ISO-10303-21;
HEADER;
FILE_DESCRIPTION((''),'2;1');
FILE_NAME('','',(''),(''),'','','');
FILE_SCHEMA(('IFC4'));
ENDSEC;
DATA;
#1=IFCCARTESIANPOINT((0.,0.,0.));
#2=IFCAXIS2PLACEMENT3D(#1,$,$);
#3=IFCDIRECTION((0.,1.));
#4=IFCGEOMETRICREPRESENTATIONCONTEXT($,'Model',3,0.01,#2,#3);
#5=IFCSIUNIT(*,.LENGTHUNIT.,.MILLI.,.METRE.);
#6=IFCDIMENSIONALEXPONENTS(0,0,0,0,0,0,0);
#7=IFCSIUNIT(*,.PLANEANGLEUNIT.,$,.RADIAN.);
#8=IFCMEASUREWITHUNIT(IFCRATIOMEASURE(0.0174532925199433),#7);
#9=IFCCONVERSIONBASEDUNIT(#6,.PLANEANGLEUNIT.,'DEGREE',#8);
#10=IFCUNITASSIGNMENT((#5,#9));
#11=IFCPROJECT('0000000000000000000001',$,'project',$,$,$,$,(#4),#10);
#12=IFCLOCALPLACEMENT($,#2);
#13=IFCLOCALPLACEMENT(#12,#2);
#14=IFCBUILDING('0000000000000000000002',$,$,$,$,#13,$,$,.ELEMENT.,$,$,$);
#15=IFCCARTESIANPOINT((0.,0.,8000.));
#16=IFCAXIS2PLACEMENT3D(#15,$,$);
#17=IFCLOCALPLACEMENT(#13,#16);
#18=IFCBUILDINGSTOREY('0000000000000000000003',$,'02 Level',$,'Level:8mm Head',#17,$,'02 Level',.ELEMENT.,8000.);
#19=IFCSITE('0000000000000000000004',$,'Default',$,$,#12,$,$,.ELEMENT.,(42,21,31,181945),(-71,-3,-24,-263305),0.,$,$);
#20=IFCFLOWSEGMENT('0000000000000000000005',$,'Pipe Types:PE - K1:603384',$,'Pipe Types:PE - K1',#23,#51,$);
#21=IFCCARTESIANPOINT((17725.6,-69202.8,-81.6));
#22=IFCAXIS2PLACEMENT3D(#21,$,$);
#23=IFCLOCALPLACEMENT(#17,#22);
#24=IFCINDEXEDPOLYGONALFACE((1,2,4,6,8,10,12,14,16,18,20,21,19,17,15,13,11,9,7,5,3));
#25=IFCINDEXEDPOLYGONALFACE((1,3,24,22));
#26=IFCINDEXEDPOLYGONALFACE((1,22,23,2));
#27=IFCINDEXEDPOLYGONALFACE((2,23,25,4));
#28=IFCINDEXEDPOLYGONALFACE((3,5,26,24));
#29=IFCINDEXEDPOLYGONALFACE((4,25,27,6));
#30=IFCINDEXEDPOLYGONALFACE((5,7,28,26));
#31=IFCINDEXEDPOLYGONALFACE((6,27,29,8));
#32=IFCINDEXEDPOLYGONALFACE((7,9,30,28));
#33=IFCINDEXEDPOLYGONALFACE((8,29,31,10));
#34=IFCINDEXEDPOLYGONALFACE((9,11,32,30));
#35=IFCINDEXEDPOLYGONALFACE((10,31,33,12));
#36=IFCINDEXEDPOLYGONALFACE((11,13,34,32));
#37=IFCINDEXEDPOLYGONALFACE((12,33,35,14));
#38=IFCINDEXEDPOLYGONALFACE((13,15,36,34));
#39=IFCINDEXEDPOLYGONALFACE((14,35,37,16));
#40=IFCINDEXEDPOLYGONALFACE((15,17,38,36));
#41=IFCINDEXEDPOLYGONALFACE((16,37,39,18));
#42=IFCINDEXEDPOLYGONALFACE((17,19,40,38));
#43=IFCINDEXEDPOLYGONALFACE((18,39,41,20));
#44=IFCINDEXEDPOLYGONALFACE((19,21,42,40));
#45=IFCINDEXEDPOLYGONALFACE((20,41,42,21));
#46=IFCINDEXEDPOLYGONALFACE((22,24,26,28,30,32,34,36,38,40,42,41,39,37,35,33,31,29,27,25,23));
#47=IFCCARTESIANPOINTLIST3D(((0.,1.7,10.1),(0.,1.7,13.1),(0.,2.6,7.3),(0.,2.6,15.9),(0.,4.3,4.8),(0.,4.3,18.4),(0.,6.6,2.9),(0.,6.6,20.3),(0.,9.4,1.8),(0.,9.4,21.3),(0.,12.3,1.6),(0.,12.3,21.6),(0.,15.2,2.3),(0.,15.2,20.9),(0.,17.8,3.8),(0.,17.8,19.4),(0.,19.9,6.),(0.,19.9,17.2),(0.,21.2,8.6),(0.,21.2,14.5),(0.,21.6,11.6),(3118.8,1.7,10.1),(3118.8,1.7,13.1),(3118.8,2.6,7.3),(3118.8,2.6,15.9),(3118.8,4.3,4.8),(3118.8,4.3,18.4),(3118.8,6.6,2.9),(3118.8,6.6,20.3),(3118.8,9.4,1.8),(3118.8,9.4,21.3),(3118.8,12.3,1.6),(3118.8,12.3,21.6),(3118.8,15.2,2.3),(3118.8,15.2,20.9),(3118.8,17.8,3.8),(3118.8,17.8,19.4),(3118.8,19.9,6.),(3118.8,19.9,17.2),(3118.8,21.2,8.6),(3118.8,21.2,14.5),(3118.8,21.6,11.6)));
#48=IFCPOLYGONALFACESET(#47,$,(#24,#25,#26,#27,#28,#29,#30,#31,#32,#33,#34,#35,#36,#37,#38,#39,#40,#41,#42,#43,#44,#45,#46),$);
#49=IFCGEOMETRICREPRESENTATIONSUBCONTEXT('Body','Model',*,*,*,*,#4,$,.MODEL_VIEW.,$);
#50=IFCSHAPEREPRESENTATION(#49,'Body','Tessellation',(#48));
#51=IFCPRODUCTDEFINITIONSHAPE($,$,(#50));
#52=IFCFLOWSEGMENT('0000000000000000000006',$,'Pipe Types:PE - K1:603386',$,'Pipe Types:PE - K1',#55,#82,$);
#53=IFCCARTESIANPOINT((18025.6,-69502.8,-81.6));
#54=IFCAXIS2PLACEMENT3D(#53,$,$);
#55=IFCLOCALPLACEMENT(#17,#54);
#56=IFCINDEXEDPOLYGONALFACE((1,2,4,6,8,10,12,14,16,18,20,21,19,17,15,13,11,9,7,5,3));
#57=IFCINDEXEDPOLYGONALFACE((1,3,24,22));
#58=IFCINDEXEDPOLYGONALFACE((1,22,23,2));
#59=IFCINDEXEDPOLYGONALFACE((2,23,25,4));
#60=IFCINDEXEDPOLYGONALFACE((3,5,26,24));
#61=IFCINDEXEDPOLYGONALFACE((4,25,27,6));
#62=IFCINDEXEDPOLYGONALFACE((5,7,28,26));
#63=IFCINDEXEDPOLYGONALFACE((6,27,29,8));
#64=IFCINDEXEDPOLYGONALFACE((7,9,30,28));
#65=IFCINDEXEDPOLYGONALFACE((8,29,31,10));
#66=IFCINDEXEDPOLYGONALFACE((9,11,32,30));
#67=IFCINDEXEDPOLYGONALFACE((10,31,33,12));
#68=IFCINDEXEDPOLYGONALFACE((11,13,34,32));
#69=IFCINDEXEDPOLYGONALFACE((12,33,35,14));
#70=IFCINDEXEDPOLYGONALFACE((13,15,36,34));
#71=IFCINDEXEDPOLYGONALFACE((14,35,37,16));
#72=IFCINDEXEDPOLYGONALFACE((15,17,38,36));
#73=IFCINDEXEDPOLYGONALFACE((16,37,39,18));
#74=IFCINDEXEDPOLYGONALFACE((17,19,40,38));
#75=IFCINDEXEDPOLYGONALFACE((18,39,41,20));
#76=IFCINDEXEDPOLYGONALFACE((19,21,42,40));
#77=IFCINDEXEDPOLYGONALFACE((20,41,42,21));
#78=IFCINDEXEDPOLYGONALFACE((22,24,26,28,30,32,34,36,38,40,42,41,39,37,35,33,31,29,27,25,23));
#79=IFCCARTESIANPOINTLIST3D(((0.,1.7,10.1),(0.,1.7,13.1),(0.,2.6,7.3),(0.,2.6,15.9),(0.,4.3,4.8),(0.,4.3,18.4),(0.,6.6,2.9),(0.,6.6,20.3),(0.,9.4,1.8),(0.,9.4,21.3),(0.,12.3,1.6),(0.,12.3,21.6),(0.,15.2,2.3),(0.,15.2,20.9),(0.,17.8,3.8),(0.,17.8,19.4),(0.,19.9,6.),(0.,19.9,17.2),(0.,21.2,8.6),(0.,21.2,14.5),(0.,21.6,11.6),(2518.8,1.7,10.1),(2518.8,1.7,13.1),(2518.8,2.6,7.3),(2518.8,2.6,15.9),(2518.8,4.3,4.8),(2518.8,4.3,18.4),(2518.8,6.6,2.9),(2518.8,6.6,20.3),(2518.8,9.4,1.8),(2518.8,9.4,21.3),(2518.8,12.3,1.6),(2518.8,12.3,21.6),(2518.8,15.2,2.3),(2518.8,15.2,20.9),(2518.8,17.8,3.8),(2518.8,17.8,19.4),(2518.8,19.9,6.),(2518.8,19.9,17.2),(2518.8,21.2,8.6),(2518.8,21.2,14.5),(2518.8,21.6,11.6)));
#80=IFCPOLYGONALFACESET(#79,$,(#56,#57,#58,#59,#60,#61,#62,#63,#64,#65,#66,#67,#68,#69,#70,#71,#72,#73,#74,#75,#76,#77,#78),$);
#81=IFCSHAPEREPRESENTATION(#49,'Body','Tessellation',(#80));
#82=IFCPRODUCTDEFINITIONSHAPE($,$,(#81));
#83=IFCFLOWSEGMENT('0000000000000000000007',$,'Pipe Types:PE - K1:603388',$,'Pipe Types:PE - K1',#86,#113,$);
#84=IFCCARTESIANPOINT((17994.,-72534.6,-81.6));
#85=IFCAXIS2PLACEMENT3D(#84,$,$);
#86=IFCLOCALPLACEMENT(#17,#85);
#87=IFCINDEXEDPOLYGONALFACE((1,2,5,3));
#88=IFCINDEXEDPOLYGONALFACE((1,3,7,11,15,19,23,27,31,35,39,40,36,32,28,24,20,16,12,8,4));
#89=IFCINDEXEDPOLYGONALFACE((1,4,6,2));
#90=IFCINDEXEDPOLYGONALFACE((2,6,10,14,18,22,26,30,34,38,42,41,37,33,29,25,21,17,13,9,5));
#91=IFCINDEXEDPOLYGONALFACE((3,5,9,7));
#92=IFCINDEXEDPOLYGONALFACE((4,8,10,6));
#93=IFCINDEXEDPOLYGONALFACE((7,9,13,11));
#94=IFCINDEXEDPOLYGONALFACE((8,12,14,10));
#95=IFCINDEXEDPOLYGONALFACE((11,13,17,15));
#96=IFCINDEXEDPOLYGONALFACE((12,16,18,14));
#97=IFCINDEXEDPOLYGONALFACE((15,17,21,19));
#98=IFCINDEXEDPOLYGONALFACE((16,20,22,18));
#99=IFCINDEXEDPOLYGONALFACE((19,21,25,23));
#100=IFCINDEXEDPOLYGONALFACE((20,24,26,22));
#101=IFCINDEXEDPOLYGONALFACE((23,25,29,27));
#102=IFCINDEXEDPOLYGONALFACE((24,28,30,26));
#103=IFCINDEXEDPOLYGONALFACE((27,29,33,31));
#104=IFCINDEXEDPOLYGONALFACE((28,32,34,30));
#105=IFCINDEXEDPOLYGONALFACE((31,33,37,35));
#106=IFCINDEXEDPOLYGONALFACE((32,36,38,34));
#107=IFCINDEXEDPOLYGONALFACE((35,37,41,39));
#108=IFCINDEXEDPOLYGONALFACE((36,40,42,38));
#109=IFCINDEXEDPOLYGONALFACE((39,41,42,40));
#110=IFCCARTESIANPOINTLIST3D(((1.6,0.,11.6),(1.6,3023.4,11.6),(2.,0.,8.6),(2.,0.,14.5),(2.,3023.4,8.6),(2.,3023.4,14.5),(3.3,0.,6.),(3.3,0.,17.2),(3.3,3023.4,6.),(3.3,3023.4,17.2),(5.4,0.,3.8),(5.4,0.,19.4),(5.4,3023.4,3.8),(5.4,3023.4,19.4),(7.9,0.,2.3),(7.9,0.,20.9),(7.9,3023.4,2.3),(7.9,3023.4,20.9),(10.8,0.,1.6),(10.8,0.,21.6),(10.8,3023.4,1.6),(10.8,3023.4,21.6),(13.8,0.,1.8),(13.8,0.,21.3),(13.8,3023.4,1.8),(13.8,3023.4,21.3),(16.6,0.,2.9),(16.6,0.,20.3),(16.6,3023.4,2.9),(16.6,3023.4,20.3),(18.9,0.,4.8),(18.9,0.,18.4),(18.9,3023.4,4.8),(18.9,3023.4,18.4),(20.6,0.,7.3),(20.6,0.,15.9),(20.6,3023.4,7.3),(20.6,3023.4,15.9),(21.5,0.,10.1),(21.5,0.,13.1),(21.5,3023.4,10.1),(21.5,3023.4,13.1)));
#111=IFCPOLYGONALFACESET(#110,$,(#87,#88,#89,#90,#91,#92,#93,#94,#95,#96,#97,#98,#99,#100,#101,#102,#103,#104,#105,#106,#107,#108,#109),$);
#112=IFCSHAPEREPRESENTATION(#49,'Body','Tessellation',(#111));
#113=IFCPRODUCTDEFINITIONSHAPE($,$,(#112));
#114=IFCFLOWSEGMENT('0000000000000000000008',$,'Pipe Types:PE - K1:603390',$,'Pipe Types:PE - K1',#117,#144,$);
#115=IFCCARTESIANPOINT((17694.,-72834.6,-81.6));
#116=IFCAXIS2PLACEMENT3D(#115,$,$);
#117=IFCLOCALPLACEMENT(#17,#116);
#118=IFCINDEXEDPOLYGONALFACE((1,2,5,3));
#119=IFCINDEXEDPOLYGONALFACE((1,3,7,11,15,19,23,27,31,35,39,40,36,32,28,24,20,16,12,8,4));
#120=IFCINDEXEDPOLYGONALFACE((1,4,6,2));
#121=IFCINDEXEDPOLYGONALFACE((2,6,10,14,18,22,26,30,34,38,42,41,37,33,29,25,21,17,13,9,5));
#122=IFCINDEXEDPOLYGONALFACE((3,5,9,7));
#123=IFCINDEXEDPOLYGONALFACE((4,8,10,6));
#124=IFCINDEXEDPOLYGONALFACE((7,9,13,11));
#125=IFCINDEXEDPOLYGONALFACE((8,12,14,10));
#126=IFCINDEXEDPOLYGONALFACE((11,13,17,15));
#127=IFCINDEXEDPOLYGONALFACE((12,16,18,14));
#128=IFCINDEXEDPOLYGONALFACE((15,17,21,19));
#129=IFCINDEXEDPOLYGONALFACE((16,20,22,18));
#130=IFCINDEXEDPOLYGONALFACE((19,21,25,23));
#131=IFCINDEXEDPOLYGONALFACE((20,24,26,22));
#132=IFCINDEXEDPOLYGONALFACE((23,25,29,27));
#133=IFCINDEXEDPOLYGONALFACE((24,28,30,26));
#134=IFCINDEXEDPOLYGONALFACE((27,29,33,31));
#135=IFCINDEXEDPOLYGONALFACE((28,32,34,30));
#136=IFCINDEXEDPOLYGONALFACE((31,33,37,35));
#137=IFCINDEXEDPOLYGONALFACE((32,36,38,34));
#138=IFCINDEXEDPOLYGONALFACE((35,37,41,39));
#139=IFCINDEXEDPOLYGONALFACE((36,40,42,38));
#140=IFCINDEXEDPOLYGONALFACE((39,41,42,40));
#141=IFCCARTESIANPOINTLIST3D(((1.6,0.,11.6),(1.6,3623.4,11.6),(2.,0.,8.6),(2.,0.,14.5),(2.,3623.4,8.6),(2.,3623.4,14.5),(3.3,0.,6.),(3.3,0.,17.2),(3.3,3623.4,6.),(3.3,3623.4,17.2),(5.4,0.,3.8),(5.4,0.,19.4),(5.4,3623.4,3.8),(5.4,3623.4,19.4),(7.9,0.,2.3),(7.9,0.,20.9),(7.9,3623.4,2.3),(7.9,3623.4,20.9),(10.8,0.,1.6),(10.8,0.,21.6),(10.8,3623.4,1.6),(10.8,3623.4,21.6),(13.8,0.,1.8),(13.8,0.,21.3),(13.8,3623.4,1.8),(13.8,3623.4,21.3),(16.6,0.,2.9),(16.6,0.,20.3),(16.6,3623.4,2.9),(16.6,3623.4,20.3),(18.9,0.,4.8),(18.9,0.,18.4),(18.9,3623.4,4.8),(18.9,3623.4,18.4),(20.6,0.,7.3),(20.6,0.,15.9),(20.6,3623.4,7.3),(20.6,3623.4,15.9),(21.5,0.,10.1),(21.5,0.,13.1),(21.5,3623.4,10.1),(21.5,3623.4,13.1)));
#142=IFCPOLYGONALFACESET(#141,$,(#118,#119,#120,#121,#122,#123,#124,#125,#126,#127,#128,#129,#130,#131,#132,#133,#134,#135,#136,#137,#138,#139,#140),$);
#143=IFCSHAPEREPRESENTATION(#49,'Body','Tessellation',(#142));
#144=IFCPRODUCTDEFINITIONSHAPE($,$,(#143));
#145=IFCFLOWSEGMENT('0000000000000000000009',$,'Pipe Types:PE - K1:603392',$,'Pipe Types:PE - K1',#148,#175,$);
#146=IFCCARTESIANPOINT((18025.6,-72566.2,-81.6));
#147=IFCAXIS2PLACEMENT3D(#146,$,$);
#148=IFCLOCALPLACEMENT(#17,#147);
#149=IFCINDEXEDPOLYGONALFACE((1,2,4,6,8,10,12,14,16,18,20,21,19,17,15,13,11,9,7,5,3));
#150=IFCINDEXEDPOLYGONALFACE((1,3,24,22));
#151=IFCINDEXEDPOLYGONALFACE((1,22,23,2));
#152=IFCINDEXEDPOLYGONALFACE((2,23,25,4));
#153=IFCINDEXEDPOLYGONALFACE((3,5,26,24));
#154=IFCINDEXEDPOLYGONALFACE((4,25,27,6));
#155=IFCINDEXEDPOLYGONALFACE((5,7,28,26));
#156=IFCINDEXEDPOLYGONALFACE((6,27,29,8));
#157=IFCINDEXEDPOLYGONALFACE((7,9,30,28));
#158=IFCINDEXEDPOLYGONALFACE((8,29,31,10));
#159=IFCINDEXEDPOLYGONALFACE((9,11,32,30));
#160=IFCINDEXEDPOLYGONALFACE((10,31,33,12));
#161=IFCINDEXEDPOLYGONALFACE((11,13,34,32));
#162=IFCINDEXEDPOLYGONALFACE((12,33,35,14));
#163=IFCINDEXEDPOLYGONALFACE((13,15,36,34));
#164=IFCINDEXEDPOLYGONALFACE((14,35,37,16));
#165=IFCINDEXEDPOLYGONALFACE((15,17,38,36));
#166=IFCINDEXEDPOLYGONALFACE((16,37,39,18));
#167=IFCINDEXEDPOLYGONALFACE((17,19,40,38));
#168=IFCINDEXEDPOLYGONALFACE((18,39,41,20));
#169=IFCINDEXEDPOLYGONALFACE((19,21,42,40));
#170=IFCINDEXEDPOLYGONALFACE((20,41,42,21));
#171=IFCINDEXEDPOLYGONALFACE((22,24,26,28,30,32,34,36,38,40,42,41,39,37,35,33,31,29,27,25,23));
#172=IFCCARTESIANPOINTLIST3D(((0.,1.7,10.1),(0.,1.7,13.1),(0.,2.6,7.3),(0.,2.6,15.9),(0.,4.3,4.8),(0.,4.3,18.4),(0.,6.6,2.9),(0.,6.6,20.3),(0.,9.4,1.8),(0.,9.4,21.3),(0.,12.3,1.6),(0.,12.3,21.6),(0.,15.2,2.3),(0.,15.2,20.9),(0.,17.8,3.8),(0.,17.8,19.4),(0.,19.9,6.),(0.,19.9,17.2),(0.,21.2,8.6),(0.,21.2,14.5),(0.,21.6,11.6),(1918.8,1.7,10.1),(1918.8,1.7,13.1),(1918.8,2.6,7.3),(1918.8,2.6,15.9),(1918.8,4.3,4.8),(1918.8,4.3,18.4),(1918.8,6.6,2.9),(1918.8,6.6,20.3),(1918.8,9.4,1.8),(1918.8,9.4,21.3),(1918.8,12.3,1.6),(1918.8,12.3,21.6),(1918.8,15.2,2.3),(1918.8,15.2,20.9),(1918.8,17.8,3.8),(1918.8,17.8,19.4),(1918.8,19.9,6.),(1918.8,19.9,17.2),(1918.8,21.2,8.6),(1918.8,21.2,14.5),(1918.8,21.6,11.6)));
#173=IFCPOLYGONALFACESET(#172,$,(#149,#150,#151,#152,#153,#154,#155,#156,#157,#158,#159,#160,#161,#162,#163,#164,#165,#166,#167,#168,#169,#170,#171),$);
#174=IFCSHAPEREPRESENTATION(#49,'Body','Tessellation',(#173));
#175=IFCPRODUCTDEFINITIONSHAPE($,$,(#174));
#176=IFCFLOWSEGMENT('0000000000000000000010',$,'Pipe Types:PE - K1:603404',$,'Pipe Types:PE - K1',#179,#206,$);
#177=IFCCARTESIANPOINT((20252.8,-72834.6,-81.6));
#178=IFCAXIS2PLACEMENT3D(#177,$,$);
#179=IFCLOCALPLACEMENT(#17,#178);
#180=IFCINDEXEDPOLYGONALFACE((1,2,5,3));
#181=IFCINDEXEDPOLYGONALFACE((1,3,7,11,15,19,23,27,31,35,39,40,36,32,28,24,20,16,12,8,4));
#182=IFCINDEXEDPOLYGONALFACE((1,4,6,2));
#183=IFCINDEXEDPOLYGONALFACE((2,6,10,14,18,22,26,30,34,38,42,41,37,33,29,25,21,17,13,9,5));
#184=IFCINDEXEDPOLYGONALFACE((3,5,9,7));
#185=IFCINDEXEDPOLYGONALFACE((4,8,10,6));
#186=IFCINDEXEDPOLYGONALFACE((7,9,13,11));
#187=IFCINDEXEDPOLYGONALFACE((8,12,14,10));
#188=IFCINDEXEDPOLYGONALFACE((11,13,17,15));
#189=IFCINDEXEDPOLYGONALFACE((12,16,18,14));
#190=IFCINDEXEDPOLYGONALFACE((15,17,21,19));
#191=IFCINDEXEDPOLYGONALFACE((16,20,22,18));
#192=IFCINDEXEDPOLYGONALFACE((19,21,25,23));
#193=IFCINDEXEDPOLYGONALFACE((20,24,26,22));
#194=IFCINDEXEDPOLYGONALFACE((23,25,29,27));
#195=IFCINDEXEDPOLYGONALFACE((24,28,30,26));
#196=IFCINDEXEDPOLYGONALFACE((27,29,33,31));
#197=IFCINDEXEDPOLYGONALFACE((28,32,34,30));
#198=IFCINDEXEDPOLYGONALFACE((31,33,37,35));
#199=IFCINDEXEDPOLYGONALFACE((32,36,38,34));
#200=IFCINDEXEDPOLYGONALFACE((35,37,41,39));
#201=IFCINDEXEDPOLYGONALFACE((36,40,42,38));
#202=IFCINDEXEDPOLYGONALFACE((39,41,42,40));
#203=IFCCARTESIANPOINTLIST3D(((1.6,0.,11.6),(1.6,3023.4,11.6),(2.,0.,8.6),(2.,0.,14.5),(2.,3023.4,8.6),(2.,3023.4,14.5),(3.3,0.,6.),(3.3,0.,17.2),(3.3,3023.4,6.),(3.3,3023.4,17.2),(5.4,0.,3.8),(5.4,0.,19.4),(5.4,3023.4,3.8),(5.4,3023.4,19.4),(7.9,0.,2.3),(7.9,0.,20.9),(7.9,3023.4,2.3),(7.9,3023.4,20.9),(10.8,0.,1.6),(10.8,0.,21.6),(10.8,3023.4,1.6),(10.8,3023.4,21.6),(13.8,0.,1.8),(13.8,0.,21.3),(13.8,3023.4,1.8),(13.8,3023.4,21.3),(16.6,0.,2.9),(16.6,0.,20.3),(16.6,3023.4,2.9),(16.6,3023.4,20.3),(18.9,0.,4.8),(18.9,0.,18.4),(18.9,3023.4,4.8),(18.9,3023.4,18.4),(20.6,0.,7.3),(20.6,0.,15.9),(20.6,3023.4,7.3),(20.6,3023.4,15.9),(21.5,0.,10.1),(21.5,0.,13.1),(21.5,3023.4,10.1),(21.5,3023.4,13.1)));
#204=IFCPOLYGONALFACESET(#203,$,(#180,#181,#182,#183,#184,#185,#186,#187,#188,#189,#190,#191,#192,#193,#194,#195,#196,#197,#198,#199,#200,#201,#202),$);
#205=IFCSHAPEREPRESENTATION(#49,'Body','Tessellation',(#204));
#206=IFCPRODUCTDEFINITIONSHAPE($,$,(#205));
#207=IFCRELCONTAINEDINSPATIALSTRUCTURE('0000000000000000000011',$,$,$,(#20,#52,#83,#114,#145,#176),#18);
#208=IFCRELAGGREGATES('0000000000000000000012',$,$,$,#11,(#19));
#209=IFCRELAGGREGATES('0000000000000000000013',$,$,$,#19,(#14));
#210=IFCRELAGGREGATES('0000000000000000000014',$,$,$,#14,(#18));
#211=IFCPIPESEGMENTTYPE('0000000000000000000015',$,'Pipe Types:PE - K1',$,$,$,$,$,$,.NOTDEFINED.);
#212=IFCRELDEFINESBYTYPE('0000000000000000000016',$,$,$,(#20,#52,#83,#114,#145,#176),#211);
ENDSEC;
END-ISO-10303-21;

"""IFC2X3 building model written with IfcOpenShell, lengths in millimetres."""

from ifc_helpers import new_model, entity, si_unit, converted_unit, direction, frame, frame_2d, origin, place, context, subcontext, project, spatial, circle, extrude, type_object, element, save


model = new_model("IFC2X3")

# Units and contexts
model_context = context("Model", 3, precision=0.01, world=origin(), true_north=direction((0.0, 1.0)))
body_context = subcontext(model_context, "Body", "Model", "MODEL_VIEW")
ifc_project = project(units=[si_unit("LENGTHUNIT", "METRE", prefix="MILLI"), converted_unit("PLANEANGLEUNIT", "DEGREE", entity("IfcRatioMeasure", 0.0174532925199433), si_unit("PLANEANGLEUNIT", "RADIAN"), dimensions=[0, 0, 0, 0, 0, 0, 0])], contexts=[model_context])

# Site, building, storey
site_placement = place(None, origin())
site = spatial("IfcSite", under=ifc_project, at=site_placement, Name="Default", CompositionType="ELEMENT", RefLatitude=(42, 21, 31, 181945), RefLongitude=(-71, -3, -24, -263305), RefElevation=0.0)
building_placement = place(site_placement, origin())
building = spatial("IfcBuilding", under=site, at=building_placement, CompositionType="ELEMENT")
storey_placement = place(building_placement, frame((0.0, 0.0, 8000.0)))
storey = spatial("IfcBuildingStorey", under=building, at=storey_placement, Name="02 Level", ObjectType="Level:8mm Head", LongName="02 Level", CompositionType="ELEMENT", Elevation=8000.0)

# Flow segments
pipe_segment_type = type_object("IfcPipeSegmentType", Name="Pipe Types:PE - K1", PredefinedType="NOTDEFINED")
flow_segment_1_placement = place(storey_placement, frame((17725.6, -69202.8, -81.6)))
element("IfcFlowSegment", 1, at=flow_segment_1_placement, inside=storey, type_object=pipe_segment_type, Name="Pipe Types:PE - K1:603384", ObjectType="Pipe Types:PE - K1", context=body_context, shape_type="SweptSolid", body=[
    extrude(circle(Radius=10.0, at=frame_2d((0.0, 0.0), x_axis=(1.0, 0.0))), frame((0.0, 11.6, 11.6), z_axis=(1.0, 0.0, 0.0), x_axis=(0.0, 1.0, 0.0)), (0.0, 0.0, 1.0), 3118.8),
])
flow_segment_2_placement = place(storey_placement, frame((18025.6, -69502.8, -81.6)))
element("IfcFlowSegment", 2, at=flow_segment_2_placement, inside=storey, type_object=pipe_segment_type, Name="Pipe Types:PE - K1:603386", ObjectType="Pipe Types:PE - K1", context=body_context, shape_type="SweptSolid", body=[
    extrude(circle(Radius=10.0, at=frame_2d((0.0, 0.0), x_axis=(1.0, 0.0))), frame((0.0, 11.6, 11.6), z_axis=(1.0, 0.0, 0.0), x_axis=(0.0, 1.0, 0.0)), (0.0, 0.0, 1.0), 2518.8),
])
flow_segment_3_placement = place(storey_placement, frame((17994.0, -72534.6, -81.6)))
element("IfcFlowSegment", 3, at=flow_segment_3_placement, inside=storey, type_object=pipe_segment_type, Name="Pipe Types:PE - K1:603388", ObjectType="Pipe Types:PE - K1", context=body_context, shape_type="SweptSolid", body=[
    extrude(circle(Radius=10.0, at=frame_2d((0.0, 0.0), x_axis=(1.0, 0.0))), frame((11.6, 0.0, 11.6), z_axis=(0.0, 1.0, 0.0), x_axis=(-1.0, 0.0, 0.0)), (0.0, 0.0, 1.0), 3023.4),
])
flow_segment_4_placement = place(storey_placement, frame((17694.0, -72834.6, -81.6)))
element("IfcFlowSegment", 4, at=flow_segment_4_placement, inside=storey, type_object=pipe_segment_type, Name="Pipe Types:PE - K1:603390", ObjectType="Pipe Types:PE - K1", context=body_context, shape_type="SweptSolid", body=[
    extrude(circle(Radius=10.0, at=frame_2d((0.0, 0.0), x_axis=(1.0, 0.0))), frame((11.6, 0.0, 11.6), z_axis=(0.0, 1.0, 0.0), x_axis=(-1.0, 0.0, 0.0)), (0.0, 0.0, 1.0), 3623.4),
])
flow_segment_5_placement = place(storey_placement, frame((18025.6, -72566.2, -81.6)))
element("IfcFlowSegment", 5, at=flow_segment_5_placement, inside=storey, type_object=pipe_segment_type, Name="Pipe Types:PE - K1:603392", ObjectType="Pipe Types:PE - K1", context=body_context, shape_type="SweptSolid", body=[
    extrude(circle(Radius=10.0, at=frame_2d((0.0, 0.0), x_axis=(1.0, 0.0))), frame((0.0, 11.6, 11.6), z_axis=(1.0, 0.0, 0.0), x_axis=(0.0, 1.0, 0.0)), (0.0, 0.0, 1.0), 1918.8),
])
flow_segment_6_placement = place(storey_placement, frame((20252.8, -72834.6, -81.6)))
element("IfcFlowSegment", 6, at=flow_segment_6_placement, inside=storey, type_object=pipe_segment_type, Name="Pipe Types:PE - K1:603404", ObjectType="Pipe Types:PE - K1", context=body_context, shape_type="SweptSolid", body=[
    extrude(circle(Radius=10.0, at=frame_2d((0.0, 0.0), x_axis=(1.0, 0.0))), frame((11.6, 0.0, 11.6), z_axis=(0.0, 1.0, 0.0), x_axis=(-1.0, 0.0, 0.0)), (0.0, 0.0, 1.0), 3023.4),
])

save(model, "model.ifc")
